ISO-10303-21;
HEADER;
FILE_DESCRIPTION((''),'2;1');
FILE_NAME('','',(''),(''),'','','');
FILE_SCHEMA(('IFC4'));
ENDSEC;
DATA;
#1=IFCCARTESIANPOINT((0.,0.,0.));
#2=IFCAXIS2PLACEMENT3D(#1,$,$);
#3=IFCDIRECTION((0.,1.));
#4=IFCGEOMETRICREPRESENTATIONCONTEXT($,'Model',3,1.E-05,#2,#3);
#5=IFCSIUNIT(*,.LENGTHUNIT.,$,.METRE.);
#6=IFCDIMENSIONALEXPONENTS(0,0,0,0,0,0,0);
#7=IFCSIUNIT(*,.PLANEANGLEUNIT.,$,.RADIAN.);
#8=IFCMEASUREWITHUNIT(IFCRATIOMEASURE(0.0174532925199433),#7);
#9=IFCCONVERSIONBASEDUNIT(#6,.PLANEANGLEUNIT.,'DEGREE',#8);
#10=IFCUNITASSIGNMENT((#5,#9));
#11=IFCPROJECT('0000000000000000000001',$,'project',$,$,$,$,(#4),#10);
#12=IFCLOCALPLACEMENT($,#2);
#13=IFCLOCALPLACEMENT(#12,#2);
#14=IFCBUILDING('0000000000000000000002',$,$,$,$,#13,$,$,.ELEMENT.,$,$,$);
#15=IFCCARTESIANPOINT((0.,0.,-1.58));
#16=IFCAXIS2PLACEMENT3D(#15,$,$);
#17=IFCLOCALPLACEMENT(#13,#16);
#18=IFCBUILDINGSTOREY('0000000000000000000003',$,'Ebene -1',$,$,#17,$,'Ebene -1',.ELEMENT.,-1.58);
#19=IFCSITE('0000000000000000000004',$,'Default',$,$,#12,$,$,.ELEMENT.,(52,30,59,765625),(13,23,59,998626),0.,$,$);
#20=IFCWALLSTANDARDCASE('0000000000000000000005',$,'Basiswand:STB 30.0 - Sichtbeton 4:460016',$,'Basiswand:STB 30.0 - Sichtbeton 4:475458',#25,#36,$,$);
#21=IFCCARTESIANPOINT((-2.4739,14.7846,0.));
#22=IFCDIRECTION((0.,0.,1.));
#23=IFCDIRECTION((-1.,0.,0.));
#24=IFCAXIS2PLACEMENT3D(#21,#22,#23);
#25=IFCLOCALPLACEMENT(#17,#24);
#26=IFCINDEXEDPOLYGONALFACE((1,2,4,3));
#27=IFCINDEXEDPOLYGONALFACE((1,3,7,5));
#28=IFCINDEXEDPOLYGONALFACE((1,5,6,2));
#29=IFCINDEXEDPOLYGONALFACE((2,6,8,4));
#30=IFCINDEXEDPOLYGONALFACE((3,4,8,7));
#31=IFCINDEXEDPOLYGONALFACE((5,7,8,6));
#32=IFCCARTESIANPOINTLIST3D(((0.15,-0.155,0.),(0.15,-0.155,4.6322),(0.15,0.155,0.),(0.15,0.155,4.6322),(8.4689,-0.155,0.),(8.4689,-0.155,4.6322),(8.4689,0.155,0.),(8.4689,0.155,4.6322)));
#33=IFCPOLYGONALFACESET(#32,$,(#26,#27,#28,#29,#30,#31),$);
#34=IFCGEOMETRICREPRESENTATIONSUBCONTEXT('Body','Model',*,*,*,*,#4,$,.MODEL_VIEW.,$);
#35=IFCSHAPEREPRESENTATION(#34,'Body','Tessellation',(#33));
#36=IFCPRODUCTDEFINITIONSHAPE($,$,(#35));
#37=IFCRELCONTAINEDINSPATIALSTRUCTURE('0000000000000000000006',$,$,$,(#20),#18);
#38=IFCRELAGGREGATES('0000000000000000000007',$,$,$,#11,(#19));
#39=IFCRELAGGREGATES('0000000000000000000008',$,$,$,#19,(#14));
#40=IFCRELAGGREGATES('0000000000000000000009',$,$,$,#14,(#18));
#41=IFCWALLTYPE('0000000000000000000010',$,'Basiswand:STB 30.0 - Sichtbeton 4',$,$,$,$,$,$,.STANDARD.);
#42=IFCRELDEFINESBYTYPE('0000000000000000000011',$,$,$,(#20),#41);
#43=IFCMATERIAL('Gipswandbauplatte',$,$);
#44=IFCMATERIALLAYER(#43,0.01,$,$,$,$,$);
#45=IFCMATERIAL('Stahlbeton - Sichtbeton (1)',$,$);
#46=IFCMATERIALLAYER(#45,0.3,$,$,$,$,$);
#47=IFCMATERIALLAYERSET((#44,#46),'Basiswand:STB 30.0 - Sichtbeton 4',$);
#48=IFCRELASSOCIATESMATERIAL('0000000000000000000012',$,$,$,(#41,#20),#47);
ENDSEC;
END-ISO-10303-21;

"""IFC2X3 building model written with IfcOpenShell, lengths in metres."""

from ifc_helpers import new_model, entity, si_unit, converted_unit, direction, frame, frame_2d, origin, place, context, subcontext, project, spatial, rectangle, extrude, material, layer, layer_set, layer_usage, type_object, element, save


model = new_model("IFC2X3")

# Units and contexts
model_context = context("Model", 3, precision=1e-05, world=origin(), true_north=direction((0.0, 1.0)))
body_context = subcontext(model_context, "Body", "Model", "MODEL_VIEW")
ifc_project = project(units=[si_unit("LENGTHUNIT", "METRE"), converted_unit("PLANEANGLEUNIT", "DEGREE", entity("IfcRatioMeasure", 0.0174532925199433), si_unit("PLANEANGLEUNIT", "RADIAN"), dimensions=[0, 0, 0, 0, 0, 0, 0])], contexts=[model_context])

# Site, building, storey
site_placement = place(None, origin())
site = spatial("IfcSite", under=ifc_project, at=site_placement, Name="Default", CompositionType="ELEMENT", RefLatitude=(52, 30, 59, 765625), RefLongitude=(13, 23, 59, 998626), RefElevation=0.0)
building_placement = place(site_placement, origin())
building = spatial("IfcBuilding", under=site, at=building_placement, CompositionType="ELEMENT")
storey_placement = place(building_placement, frame((0.0, 0.0, -1.58)))
storey = spatial("IfcBuildingStorey", under=building, at=storey_placement, Name="Ebene -1", LongName="Ebene -1", CompositionType="ELEMENT", Elevation=-1.58)

# Shared definitions
ifc_material_1 = material(Name="Stahlbeton - Sichtbeton (1)")
ifc_material_2 = material(Name="Gipswandbauplatte")

# Wall
ifc_layer_1 = layer(ifc_material_2, 0.01)
ifc_layer_2 = layer(ifc_material_1, 0.3)
ifc_layer_set_1 = layer_set([ifc_layer_1, ifc_layer_2], Name="Basiswand:STB 30.0 - Sichtbeton 4")
ifc_layer_usage_1 = layer_usage(ifc_layer_set_1, "AXIS2", "NEGATIVE", 0.155)
wall_type_1 = type_object("IfcWallType", Name="Basiswand:STB 30.0 - Sichtbeton 4", PredefinedType="STANDARD", material=ifc_layer_set_1)
wall_1_placement = place(storey_placement, frame((-2.4739, 14.7846, 0.0), z_axis=(0.0, 0.0, 1.0), x_axis=(-1.0, 0.0, 0.0)))
element("IfcWallStandardCase", 1, at=wall_1_placement, inside=storey, type_object=wall_type_1, material=ifc_layer_usage_1, Name="Basiswand:STB 30.0 - Sichtbeton 4:460016", ObjectType="Basiswand:STB 30.0 - Sichtbeton 4:475458", context=body_context, shape_type="SweptSolid", body=[
    extrude(rectangle(XDim=8.3189, YDim=0.31, at=frame_2d((4.3094, 0.0), x_axis=(-1.0, 0.0))), origin(), (0.0, 0.0, 1.0), 4.6322),
])

save(model, "model.ifc")
